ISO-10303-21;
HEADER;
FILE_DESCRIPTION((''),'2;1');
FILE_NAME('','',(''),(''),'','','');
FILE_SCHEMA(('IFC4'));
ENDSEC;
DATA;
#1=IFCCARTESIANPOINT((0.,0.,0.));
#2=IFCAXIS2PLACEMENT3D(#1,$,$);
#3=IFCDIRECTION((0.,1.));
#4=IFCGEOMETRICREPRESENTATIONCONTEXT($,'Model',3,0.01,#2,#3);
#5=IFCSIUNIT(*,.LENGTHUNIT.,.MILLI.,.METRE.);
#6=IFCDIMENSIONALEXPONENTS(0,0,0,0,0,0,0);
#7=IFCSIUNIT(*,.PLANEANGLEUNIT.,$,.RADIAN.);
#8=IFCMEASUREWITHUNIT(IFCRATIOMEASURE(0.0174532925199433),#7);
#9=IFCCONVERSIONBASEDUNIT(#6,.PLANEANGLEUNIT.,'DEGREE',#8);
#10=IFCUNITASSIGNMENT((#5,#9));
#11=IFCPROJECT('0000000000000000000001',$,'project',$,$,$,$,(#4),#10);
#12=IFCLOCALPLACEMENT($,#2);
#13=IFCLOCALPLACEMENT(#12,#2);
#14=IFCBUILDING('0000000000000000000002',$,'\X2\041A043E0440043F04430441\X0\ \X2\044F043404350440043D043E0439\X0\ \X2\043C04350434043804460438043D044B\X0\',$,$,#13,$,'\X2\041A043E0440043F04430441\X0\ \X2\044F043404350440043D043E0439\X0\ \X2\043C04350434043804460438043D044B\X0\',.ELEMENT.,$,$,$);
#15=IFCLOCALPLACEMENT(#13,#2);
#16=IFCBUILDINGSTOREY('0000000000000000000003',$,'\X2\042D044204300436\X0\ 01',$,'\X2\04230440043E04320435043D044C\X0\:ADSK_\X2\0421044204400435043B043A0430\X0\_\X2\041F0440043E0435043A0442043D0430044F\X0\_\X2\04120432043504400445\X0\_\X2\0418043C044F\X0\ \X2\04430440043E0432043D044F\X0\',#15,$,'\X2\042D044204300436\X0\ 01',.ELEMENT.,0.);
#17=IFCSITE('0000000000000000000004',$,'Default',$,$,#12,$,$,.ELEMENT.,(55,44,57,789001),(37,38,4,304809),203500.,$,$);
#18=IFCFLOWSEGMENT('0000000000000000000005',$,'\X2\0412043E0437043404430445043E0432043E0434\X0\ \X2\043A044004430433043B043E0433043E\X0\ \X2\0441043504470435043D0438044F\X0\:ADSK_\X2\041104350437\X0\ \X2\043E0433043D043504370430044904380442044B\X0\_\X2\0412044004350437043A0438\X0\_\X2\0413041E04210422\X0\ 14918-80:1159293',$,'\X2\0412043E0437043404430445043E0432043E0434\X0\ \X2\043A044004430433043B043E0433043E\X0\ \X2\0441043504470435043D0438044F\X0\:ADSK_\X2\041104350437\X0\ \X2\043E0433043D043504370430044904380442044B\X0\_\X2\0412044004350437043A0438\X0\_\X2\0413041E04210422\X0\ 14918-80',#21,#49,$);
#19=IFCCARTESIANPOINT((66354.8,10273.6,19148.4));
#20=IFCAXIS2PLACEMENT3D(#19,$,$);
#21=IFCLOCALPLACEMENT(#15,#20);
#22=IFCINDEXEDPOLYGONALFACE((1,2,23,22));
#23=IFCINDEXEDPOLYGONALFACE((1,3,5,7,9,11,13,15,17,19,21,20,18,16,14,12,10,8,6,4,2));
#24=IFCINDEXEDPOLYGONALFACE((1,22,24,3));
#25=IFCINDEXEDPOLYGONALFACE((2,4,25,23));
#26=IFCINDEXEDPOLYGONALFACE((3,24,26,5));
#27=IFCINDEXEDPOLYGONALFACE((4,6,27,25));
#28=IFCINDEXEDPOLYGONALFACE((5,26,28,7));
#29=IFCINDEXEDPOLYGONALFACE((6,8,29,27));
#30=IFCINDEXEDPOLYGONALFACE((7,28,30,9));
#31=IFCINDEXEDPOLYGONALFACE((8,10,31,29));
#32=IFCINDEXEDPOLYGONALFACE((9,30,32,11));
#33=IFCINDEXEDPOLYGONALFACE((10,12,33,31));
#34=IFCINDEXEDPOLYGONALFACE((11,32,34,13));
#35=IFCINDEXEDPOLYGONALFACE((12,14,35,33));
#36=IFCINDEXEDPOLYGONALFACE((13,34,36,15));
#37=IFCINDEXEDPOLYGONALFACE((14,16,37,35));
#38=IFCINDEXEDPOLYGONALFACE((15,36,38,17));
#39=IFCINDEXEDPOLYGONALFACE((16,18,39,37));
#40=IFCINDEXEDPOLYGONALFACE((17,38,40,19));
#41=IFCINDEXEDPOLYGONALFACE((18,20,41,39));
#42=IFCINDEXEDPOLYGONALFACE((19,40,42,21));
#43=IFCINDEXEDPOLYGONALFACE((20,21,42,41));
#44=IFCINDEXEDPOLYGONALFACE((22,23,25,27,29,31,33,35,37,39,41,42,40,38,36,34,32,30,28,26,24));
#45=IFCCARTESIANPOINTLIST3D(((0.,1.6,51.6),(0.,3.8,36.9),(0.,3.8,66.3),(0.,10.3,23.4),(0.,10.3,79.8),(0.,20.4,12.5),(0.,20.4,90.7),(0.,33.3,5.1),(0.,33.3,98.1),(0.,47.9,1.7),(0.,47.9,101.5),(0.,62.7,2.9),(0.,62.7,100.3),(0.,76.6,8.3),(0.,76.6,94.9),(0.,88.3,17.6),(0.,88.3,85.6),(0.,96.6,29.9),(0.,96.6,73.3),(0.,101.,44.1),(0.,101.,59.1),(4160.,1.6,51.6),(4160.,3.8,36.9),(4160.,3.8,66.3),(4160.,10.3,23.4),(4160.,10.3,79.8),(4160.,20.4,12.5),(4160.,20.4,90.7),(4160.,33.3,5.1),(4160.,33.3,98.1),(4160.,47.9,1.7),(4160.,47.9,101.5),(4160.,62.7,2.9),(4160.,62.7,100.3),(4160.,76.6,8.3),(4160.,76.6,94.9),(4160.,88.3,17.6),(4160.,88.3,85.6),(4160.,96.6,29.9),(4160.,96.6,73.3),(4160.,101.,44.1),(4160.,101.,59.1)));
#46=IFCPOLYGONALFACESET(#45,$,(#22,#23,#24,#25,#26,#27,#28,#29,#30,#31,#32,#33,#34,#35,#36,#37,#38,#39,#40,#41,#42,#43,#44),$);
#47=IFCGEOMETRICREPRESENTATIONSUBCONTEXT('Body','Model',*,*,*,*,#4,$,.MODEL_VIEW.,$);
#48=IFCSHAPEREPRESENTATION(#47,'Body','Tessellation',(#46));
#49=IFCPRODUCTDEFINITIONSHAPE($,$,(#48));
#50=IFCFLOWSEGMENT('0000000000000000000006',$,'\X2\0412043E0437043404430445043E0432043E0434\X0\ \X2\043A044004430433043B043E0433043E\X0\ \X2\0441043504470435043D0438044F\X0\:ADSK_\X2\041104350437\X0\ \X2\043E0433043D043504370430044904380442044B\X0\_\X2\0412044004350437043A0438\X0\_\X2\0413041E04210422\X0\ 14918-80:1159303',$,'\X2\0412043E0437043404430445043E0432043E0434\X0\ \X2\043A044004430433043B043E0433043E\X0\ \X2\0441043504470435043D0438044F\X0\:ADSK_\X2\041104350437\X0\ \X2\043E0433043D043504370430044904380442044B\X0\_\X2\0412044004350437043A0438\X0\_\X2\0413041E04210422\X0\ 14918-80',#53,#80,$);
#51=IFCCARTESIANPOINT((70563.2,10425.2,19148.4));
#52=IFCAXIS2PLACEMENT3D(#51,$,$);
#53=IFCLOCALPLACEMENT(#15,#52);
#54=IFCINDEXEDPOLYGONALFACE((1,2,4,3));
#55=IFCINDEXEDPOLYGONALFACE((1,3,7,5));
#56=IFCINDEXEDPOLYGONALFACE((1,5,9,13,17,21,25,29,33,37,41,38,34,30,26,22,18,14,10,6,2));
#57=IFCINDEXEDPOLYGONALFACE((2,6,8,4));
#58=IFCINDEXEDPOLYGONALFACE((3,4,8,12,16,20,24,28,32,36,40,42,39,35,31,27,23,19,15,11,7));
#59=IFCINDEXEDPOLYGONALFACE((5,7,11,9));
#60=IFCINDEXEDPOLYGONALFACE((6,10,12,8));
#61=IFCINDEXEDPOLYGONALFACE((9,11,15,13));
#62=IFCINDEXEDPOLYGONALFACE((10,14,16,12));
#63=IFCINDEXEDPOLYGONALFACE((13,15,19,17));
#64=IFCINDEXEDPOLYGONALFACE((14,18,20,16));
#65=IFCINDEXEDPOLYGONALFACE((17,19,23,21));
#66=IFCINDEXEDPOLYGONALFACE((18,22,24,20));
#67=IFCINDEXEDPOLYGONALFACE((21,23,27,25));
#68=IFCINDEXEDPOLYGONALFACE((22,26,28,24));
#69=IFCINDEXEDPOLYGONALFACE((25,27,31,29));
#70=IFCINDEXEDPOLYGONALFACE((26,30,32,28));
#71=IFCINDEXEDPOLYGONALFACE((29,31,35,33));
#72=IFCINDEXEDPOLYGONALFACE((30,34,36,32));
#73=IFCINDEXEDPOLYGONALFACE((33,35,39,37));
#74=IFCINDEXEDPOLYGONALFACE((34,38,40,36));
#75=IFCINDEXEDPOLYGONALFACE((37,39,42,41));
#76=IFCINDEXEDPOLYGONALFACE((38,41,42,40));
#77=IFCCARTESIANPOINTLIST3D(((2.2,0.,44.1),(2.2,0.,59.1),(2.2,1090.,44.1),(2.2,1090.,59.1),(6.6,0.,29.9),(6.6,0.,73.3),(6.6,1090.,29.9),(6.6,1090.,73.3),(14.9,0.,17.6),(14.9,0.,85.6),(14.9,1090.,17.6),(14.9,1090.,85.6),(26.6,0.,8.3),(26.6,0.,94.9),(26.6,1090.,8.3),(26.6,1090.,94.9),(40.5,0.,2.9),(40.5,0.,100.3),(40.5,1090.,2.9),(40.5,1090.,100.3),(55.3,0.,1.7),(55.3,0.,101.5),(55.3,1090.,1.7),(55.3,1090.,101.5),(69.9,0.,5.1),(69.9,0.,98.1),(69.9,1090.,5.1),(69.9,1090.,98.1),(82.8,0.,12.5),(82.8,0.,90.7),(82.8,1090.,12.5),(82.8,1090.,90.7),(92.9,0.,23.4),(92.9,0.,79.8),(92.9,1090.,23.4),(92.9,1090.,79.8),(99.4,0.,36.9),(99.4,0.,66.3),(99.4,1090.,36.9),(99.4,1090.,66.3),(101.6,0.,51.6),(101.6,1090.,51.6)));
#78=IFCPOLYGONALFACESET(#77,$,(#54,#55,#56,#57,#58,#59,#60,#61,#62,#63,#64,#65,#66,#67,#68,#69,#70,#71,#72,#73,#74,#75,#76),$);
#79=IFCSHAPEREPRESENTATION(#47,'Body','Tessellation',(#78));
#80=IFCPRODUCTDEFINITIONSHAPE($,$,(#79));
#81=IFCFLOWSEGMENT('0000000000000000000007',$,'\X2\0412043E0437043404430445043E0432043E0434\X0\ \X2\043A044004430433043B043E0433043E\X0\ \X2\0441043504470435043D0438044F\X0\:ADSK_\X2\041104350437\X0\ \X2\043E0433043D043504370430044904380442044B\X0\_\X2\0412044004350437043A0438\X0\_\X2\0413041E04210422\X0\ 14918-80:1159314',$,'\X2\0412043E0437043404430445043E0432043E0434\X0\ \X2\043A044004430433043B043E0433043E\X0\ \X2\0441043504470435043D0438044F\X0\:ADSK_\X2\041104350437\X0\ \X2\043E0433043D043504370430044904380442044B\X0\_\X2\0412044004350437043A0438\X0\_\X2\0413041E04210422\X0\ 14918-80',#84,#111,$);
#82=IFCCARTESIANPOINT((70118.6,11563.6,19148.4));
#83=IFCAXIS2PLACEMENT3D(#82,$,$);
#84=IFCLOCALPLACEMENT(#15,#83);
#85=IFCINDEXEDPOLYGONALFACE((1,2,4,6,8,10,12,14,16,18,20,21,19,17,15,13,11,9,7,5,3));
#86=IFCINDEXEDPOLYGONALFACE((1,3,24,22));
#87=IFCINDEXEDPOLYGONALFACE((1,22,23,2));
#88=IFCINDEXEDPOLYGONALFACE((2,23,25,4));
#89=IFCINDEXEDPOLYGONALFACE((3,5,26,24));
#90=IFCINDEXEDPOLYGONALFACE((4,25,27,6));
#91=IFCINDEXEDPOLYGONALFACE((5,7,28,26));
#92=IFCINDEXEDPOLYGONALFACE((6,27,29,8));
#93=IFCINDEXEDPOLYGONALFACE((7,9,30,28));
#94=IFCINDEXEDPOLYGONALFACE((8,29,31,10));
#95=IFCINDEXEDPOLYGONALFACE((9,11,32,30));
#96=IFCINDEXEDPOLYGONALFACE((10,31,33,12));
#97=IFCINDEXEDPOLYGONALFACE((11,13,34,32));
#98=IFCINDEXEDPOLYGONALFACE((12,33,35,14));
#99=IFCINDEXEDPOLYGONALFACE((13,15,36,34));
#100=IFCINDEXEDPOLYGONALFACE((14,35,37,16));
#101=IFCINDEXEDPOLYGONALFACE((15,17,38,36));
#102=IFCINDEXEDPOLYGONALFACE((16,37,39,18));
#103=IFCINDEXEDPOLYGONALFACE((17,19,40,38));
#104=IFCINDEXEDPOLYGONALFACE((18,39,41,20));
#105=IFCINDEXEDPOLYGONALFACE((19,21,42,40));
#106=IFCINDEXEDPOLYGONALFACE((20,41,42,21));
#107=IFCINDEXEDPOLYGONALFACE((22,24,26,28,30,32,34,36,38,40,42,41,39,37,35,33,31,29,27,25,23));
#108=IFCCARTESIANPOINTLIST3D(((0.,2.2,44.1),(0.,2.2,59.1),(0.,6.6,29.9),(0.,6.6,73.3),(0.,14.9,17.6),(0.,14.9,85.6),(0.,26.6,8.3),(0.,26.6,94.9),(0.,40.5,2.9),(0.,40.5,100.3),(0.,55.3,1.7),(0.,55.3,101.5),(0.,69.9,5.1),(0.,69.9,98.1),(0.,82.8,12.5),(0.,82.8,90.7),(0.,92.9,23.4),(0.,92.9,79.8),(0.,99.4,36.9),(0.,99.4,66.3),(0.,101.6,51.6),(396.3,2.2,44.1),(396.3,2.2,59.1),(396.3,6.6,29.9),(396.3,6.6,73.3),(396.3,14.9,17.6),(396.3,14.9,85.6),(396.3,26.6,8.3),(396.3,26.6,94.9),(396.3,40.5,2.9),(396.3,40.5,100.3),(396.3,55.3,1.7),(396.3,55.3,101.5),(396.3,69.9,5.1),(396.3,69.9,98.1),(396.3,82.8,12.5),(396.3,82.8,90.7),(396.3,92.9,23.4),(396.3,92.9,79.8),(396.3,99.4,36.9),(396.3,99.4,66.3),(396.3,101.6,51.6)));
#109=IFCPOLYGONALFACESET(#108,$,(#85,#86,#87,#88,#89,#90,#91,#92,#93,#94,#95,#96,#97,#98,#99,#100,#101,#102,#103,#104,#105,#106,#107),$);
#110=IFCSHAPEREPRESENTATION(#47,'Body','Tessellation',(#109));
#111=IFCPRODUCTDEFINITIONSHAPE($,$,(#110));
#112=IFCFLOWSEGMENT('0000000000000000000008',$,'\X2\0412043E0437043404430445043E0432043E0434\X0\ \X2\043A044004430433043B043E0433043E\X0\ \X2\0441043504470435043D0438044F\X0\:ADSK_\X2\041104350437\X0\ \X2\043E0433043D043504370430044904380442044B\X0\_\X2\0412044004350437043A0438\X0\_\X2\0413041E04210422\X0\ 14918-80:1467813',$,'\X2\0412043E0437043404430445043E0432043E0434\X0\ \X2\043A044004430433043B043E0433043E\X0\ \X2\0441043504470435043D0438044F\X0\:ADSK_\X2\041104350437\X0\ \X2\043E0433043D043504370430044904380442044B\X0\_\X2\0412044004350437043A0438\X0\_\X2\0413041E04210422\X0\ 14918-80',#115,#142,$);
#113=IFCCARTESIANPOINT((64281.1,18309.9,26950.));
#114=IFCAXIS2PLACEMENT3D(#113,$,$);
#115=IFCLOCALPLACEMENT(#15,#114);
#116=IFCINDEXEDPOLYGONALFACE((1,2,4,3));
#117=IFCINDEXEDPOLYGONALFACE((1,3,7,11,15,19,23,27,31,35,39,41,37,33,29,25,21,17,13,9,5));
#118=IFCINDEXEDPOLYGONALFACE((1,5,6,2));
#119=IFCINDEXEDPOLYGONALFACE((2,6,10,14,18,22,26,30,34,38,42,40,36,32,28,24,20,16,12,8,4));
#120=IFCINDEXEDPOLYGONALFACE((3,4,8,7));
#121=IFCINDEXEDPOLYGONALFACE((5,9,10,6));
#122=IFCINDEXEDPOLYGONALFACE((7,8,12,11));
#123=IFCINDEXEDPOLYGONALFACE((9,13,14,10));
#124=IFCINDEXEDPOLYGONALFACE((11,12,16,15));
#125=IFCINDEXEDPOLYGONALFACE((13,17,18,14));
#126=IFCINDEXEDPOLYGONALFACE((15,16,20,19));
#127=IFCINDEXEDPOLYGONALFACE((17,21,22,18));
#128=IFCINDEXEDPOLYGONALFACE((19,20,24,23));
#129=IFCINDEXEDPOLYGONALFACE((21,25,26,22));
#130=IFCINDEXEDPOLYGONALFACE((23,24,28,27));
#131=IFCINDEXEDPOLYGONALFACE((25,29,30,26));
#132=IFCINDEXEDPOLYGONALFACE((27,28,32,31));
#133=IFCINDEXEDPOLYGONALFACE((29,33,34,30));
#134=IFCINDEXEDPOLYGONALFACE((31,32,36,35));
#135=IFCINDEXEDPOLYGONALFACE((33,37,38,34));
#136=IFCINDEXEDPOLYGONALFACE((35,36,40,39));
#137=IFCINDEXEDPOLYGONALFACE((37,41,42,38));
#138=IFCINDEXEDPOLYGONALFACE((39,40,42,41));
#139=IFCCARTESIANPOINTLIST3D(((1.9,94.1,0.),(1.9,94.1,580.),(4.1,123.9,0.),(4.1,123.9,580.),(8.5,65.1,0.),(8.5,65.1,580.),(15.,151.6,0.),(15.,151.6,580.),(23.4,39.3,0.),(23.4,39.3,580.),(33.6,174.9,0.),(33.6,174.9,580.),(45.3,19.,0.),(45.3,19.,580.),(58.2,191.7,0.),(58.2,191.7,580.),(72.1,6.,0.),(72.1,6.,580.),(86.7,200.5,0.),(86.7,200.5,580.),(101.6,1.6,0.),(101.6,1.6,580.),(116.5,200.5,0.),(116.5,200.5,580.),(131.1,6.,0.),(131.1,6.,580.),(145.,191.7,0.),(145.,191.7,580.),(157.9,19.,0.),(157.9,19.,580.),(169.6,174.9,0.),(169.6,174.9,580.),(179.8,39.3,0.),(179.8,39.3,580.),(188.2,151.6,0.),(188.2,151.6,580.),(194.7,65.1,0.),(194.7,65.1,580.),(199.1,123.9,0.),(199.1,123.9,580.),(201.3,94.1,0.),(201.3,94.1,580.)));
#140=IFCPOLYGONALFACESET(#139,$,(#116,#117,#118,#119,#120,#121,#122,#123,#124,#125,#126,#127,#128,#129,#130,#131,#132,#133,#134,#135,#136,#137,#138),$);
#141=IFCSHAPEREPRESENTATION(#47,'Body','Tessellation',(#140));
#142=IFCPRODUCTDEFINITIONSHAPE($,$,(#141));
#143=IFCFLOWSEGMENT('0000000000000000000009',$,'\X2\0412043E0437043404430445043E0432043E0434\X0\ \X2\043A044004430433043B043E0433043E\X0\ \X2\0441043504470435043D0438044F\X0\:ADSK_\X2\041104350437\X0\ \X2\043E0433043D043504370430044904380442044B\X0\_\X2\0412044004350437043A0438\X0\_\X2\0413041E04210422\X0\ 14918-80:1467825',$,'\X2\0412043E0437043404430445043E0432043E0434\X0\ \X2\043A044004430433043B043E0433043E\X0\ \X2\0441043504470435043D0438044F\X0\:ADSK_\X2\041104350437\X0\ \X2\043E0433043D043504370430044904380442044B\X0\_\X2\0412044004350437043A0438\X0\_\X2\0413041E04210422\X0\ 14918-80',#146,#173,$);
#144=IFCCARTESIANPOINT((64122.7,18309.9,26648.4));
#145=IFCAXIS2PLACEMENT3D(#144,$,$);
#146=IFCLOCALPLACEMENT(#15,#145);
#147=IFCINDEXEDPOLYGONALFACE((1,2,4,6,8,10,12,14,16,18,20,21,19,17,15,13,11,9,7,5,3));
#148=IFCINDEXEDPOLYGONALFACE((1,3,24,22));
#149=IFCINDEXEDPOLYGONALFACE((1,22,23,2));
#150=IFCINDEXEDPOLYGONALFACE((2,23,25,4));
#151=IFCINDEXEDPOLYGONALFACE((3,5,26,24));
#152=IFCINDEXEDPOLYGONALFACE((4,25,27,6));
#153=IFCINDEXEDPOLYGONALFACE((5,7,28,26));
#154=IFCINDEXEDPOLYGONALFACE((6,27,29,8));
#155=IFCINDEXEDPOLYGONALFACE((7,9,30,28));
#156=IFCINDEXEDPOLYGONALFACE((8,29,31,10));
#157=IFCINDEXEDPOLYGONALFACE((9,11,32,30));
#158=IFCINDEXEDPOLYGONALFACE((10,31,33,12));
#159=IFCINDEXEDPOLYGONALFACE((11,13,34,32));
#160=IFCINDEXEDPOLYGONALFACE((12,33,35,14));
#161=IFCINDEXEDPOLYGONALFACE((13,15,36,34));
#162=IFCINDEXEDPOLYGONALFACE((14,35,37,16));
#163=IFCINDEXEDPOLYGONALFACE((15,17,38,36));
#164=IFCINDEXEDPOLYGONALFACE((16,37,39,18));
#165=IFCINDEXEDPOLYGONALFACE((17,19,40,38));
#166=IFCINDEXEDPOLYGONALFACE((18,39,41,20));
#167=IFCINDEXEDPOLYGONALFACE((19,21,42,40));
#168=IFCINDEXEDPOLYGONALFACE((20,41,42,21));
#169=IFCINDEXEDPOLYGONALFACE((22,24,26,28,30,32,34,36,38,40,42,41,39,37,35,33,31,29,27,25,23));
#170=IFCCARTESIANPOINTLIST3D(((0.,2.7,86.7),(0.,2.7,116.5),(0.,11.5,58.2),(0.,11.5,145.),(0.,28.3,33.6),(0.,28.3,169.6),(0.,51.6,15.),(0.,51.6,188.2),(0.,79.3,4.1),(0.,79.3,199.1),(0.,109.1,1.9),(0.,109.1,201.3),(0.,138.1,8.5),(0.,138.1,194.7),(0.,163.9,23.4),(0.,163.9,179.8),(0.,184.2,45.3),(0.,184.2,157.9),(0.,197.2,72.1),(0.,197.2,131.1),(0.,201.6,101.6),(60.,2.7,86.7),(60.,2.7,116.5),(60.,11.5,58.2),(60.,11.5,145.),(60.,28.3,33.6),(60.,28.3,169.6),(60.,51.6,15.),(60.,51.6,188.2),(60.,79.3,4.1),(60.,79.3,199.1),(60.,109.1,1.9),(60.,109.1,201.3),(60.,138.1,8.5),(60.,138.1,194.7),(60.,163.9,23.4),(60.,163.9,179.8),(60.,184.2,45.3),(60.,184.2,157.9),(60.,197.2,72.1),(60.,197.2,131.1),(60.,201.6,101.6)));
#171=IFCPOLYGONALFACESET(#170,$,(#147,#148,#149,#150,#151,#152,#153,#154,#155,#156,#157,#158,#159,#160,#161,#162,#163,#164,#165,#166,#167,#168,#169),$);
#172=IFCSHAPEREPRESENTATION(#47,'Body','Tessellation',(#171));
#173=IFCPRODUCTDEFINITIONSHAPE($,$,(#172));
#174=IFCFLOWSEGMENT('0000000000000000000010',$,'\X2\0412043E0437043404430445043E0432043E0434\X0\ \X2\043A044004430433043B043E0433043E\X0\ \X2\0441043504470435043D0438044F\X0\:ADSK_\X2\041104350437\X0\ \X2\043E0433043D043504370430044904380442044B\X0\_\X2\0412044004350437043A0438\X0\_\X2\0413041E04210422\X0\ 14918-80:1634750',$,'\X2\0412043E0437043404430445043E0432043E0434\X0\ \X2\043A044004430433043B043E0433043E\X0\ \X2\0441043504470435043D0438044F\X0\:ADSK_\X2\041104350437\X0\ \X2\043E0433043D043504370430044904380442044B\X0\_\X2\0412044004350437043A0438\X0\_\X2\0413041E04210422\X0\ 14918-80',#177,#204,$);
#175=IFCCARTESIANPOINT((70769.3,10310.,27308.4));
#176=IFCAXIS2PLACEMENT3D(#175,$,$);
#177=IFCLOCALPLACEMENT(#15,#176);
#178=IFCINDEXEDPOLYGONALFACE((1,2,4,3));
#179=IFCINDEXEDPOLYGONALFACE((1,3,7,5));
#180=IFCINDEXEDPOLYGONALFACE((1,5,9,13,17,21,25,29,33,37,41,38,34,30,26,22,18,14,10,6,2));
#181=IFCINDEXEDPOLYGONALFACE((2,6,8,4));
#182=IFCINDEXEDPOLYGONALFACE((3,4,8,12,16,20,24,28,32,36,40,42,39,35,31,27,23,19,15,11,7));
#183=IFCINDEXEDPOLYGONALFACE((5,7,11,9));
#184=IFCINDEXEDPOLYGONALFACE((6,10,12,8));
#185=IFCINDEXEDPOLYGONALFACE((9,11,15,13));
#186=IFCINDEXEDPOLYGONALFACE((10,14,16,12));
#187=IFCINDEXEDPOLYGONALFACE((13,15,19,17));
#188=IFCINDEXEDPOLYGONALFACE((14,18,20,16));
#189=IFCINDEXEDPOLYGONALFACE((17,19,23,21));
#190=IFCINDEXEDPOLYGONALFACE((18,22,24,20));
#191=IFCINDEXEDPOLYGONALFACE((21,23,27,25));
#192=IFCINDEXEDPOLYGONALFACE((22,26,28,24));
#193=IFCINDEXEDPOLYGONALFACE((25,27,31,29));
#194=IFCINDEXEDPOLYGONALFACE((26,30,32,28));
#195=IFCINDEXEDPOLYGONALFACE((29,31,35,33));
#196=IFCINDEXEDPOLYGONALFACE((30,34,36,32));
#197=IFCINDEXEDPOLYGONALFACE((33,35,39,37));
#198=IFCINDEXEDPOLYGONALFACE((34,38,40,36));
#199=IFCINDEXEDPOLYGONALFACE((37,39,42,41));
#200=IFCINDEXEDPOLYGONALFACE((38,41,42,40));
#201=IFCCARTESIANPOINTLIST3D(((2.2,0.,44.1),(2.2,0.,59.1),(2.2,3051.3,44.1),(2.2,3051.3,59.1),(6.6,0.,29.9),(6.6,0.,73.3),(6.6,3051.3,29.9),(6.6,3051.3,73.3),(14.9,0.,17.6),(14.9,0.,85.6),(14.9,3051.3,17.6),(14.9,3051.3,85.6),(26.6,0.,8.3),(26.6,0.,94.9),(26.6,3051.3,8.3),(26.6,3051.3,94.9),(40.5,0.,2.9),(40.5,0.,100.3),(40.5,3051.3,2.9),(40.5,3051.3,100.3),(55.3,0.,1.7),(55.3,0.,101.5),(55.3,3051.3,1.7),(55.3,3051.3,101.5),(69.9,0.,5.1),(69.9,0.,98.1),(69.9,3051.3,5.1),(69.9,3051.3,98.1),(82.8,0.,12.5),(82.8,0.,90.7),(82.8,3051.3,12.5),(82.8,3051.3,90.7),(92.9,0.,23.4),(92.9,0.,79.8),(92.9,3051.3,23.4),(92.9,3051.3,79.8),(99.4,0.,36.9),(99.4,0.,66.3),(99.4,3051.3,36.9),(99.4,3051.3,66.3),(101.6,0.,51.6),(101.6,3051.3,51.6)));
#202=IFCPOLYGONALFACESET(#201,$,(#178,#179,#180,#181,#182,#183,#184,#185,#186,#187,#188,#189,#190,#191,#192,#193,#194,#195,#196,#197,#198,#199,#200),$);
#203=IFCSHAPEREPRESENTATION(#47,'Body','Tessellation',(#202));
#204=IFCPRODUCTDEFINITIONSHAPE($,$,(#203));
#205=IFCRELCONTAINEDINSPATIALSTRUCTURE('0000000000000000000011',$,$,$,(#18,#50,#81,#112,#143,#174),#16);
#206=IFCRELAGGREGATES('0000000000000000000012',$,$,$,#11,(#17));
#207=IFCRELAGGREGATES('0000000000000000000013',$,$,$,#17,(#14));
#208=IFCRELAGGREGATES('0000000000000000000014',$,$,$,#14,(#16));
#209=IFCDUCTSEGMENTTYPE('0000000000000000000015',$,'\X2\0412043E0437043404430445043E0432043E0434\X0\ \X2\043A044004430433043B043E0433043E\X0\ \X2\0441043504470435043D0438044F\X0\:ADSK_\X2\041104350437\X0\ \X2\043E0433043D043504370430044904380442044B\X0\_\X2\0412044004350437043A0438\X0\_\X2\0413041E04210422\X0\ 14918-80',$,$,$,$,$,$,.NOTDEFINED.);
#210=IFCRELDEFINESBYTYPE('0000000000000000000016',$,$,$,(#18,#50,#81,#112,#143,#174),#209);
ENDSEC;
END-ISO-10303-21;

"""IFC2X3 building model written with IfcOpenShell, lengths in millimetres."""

from ifc_helpers import new_model, entity, si_unit, converted_unit, direction, frame, origin, origin_2d_with_axis, place, context, subcontext, project, spatial, circle, extrude, type_object, element, save


model = new_model("IFC2X3")

# Units and contexts
model_context = context("Model", 3, precision=0.01, world=origin(), true_north=direction((0.0, 1.0)))
body_context = subcontext(model_context, "Body", "Model", "MODEL_VIEW")
ifc_project = project(units=[si_unit("LENGTHUNIT", "METRE", prefix="MILLI"), converted_unit("PLANEANGLEUNIT", "DEGREE", entity("IfcRatioMeasure", 0.0174532925199433), si_unit("PLANEANGLEUNIT", "RADIAN"), dimensions=[0, 0, 0, 0, 0, 0, 0])], contexts=[model_context])

# Site, building, storey
site_placement = place(None, origin())
site = spatial("IfcSite", under=ifc_project, at=site_placement, Name="Default", CompositionType="ELEMENT", RefLatitude=(55, 44, 57, 789001), RefLongitude=(37, 38, 4, 304809), RefElevation=203500.0)
building_placement = place(site_placement, origin())
building = spatial("IfcBuilding", under=site, at=building_placement, Name="Корпус ядерной медицины", LongName="Корпус ядерной медицины", CompositionType="ELEMENT")
storey_placement = place(building_placement, origin())
storey = spatial("IfcBuildingStorey", under=building, at=storey_placement, Name="Этаж 01", ObjectType="Уровень:ADSK_Стрелка_Проектная_Вверх_Имя уровня", LongName="Этаж 01", CompositionType="ELEMENT", Elevation=0.0)

# Flow segments
duct_segment_type_1 = type_object("IfcDuctSegmentType", Name="Воздуховод круглого сечения:ADSK_Без огнезащиты_Врезки_ГОСТ 14918-80", PredefinedType="NOTDEFINED")
flow_segment_1_placement = place(storey_placement, frame((66354.8, 10273.6, 19148.4)))
element("IfcFlowSegment", 1, at=flow_segment_1_placement, inside=storey, type_object=duct_segment_type_1, Name="Воздуховод круглого сечения:ADSK_Без огнезащиты_Врезки_ГОСТ 14918-80:1159293", ObjectType="Воздуховод круглого сечения:ADSK_Без огнезащиты_Врезки_ГОСТ 14918-80", context=body_context, shape_type="SweptSolid", body=[
    extrude(circle(Radius=50.0, at=origin_2d_with_axis()), frame((0.0, 51.6, 51.6), z_axis=(1.0, 0.0, 0.0), x_axis=(0.0, -1.0, 0.0)), (0.0, 0.0, 1.0), 4160.0),
])
flow_segment_2_placement = place(storey_placement, frame((70563.2, 10425.2, 19148.4)))
element("IfcFlowSegment", 2, at=flow_segment_2_placement, inside=storey, type_object=duct_segment_type_1, Name="Воздуховод круглого сечения:ADSK_Без огнезащиты_Врезки_ГОСТ 14918-80:1159303", ObjectType="Воздуховод круглого сечения:ADSK_Без огнезащиты_Врезки_ГОСТ 14918-80", context=body_context, shape_type="SweptSolid", body=[
    extrude(circle(Radius=50.0, at=origin_2d_with_axis()), frame((51.6, 0.0, 51.6), z_axis=(0.0, 1.0, 0.0), x_axis=(1.0, 0.0, 0.0)), (0.0, 0.0, 1.0), 1090.0),
])
flow_segment_3_placement = place(storey_placement, frame((70118.6, 11563.6, 19148.4)))
element("IfcFlowSegment", 3, at=flow_segment_3_placement, inside=storey, type_object=duct_segment_type_1, Name="Воздуховод круглого сечения:ADSK_Без огнезащиты_Врезки_ГОСТ 14918-80:1159314", ObjectType="Воздуховод круглого сечения:ADSK_Без огнезащиты_Врезки_ГОСТ 14918-80", context=body_context, shape_type="SweptSolid", body=[
    extrude(circle(Radius=50.0, at=origin_2d_with_axis()), frame((0.0, 51.6, 51.6), z_axis=(1.0, 0.0, 0.0), x_axis=(0.0, 1.0, 0.0)), (0.0, 0.0, 1.0), 396.3),
])
flow_segment_4_placement = place(storey_placement, frame((64281.1, 18309.9, 26950.0)))
element("IfcFlowSegment", 4, at=flow_segment_4_placement, inside=storey, type_object=duct_segment_type_1, Name="Воздуховод круглого сечения:ADSK_Без огнезащиты_Врезки_ГОСТ 14918-80:1467813", ObjectType="Воздуховод круглого сечения:ADSK_Без огнезащиты_Врезки_ГОСТ 14918-80", context=body_context, shape_type="SweptSolid", body=[
    extrude(circle(Radius=100.0, at=origin_2d_with_axis()), frame((101.6, 101.6, 0.0), z_axis=(0.0, 0.0, 1.0), x_axis=(0.0, -1.0, 0.0)), (0.0, 0.0, 1.0), 580.0),
])
flow_segment_5_placement = place(storey_placement, frame((64122.7, 18309.9, 26648.4)))
element("IfcFlowSegment", 5, at=flow_segment_5_placement, inside=storey, type_object=duct_segment_type_1, Name="Воздуховод круглого сечения:ADSK_Без огнезащиты_Врезки_ГОСТ 14918-80:1467825", ObjectType="Воздуховод круглого сечения:ADSK_Без огнезащиты_Врезки_ГОСТ 14918-80", context=body_context, shape_type="SweptSolid", body=[
    extrude(circle(Radius=100.0, at=origin_2d_with_axis()), frame((0.0, 101.6, 101.6), z_axis=(1.0, 0.0, 0.0), x_axis=(0.0, 1.0, 0.0)), (0.0, 0.0, 1.0), 60.0),
])
flow_segment_6_placement = place(storey_placement, frame((70769.3, 10310.0, 27308.4)))
element("IfcFlowSegment", 6, at=flow_segment_6_placement, inside=storey, type_object=duct_segment_type_1, Name="Воздуховод круглого сечения:ADSK_Без огнезащиты_Врезки_ГОСТ 14918-80:1634750", ObjectType="Воздуховод круглого сечения:ADSK_Без огнезащиты_Врезки_ГОСТ 14918-80", context=body_context, shape_type="SweptSolid", body=[
    extrude(circle(Radius=50.0, at=origin_2d_with_axis()), frame((51.6, 0.0, 51.6), z_axis=(0.0, 1.0, 0.0), x_axis=(1.0, 0.0, 0.0)), (0.0, 0.0, 1.0), 3051.3),
])

save(model, "model.ifc")
